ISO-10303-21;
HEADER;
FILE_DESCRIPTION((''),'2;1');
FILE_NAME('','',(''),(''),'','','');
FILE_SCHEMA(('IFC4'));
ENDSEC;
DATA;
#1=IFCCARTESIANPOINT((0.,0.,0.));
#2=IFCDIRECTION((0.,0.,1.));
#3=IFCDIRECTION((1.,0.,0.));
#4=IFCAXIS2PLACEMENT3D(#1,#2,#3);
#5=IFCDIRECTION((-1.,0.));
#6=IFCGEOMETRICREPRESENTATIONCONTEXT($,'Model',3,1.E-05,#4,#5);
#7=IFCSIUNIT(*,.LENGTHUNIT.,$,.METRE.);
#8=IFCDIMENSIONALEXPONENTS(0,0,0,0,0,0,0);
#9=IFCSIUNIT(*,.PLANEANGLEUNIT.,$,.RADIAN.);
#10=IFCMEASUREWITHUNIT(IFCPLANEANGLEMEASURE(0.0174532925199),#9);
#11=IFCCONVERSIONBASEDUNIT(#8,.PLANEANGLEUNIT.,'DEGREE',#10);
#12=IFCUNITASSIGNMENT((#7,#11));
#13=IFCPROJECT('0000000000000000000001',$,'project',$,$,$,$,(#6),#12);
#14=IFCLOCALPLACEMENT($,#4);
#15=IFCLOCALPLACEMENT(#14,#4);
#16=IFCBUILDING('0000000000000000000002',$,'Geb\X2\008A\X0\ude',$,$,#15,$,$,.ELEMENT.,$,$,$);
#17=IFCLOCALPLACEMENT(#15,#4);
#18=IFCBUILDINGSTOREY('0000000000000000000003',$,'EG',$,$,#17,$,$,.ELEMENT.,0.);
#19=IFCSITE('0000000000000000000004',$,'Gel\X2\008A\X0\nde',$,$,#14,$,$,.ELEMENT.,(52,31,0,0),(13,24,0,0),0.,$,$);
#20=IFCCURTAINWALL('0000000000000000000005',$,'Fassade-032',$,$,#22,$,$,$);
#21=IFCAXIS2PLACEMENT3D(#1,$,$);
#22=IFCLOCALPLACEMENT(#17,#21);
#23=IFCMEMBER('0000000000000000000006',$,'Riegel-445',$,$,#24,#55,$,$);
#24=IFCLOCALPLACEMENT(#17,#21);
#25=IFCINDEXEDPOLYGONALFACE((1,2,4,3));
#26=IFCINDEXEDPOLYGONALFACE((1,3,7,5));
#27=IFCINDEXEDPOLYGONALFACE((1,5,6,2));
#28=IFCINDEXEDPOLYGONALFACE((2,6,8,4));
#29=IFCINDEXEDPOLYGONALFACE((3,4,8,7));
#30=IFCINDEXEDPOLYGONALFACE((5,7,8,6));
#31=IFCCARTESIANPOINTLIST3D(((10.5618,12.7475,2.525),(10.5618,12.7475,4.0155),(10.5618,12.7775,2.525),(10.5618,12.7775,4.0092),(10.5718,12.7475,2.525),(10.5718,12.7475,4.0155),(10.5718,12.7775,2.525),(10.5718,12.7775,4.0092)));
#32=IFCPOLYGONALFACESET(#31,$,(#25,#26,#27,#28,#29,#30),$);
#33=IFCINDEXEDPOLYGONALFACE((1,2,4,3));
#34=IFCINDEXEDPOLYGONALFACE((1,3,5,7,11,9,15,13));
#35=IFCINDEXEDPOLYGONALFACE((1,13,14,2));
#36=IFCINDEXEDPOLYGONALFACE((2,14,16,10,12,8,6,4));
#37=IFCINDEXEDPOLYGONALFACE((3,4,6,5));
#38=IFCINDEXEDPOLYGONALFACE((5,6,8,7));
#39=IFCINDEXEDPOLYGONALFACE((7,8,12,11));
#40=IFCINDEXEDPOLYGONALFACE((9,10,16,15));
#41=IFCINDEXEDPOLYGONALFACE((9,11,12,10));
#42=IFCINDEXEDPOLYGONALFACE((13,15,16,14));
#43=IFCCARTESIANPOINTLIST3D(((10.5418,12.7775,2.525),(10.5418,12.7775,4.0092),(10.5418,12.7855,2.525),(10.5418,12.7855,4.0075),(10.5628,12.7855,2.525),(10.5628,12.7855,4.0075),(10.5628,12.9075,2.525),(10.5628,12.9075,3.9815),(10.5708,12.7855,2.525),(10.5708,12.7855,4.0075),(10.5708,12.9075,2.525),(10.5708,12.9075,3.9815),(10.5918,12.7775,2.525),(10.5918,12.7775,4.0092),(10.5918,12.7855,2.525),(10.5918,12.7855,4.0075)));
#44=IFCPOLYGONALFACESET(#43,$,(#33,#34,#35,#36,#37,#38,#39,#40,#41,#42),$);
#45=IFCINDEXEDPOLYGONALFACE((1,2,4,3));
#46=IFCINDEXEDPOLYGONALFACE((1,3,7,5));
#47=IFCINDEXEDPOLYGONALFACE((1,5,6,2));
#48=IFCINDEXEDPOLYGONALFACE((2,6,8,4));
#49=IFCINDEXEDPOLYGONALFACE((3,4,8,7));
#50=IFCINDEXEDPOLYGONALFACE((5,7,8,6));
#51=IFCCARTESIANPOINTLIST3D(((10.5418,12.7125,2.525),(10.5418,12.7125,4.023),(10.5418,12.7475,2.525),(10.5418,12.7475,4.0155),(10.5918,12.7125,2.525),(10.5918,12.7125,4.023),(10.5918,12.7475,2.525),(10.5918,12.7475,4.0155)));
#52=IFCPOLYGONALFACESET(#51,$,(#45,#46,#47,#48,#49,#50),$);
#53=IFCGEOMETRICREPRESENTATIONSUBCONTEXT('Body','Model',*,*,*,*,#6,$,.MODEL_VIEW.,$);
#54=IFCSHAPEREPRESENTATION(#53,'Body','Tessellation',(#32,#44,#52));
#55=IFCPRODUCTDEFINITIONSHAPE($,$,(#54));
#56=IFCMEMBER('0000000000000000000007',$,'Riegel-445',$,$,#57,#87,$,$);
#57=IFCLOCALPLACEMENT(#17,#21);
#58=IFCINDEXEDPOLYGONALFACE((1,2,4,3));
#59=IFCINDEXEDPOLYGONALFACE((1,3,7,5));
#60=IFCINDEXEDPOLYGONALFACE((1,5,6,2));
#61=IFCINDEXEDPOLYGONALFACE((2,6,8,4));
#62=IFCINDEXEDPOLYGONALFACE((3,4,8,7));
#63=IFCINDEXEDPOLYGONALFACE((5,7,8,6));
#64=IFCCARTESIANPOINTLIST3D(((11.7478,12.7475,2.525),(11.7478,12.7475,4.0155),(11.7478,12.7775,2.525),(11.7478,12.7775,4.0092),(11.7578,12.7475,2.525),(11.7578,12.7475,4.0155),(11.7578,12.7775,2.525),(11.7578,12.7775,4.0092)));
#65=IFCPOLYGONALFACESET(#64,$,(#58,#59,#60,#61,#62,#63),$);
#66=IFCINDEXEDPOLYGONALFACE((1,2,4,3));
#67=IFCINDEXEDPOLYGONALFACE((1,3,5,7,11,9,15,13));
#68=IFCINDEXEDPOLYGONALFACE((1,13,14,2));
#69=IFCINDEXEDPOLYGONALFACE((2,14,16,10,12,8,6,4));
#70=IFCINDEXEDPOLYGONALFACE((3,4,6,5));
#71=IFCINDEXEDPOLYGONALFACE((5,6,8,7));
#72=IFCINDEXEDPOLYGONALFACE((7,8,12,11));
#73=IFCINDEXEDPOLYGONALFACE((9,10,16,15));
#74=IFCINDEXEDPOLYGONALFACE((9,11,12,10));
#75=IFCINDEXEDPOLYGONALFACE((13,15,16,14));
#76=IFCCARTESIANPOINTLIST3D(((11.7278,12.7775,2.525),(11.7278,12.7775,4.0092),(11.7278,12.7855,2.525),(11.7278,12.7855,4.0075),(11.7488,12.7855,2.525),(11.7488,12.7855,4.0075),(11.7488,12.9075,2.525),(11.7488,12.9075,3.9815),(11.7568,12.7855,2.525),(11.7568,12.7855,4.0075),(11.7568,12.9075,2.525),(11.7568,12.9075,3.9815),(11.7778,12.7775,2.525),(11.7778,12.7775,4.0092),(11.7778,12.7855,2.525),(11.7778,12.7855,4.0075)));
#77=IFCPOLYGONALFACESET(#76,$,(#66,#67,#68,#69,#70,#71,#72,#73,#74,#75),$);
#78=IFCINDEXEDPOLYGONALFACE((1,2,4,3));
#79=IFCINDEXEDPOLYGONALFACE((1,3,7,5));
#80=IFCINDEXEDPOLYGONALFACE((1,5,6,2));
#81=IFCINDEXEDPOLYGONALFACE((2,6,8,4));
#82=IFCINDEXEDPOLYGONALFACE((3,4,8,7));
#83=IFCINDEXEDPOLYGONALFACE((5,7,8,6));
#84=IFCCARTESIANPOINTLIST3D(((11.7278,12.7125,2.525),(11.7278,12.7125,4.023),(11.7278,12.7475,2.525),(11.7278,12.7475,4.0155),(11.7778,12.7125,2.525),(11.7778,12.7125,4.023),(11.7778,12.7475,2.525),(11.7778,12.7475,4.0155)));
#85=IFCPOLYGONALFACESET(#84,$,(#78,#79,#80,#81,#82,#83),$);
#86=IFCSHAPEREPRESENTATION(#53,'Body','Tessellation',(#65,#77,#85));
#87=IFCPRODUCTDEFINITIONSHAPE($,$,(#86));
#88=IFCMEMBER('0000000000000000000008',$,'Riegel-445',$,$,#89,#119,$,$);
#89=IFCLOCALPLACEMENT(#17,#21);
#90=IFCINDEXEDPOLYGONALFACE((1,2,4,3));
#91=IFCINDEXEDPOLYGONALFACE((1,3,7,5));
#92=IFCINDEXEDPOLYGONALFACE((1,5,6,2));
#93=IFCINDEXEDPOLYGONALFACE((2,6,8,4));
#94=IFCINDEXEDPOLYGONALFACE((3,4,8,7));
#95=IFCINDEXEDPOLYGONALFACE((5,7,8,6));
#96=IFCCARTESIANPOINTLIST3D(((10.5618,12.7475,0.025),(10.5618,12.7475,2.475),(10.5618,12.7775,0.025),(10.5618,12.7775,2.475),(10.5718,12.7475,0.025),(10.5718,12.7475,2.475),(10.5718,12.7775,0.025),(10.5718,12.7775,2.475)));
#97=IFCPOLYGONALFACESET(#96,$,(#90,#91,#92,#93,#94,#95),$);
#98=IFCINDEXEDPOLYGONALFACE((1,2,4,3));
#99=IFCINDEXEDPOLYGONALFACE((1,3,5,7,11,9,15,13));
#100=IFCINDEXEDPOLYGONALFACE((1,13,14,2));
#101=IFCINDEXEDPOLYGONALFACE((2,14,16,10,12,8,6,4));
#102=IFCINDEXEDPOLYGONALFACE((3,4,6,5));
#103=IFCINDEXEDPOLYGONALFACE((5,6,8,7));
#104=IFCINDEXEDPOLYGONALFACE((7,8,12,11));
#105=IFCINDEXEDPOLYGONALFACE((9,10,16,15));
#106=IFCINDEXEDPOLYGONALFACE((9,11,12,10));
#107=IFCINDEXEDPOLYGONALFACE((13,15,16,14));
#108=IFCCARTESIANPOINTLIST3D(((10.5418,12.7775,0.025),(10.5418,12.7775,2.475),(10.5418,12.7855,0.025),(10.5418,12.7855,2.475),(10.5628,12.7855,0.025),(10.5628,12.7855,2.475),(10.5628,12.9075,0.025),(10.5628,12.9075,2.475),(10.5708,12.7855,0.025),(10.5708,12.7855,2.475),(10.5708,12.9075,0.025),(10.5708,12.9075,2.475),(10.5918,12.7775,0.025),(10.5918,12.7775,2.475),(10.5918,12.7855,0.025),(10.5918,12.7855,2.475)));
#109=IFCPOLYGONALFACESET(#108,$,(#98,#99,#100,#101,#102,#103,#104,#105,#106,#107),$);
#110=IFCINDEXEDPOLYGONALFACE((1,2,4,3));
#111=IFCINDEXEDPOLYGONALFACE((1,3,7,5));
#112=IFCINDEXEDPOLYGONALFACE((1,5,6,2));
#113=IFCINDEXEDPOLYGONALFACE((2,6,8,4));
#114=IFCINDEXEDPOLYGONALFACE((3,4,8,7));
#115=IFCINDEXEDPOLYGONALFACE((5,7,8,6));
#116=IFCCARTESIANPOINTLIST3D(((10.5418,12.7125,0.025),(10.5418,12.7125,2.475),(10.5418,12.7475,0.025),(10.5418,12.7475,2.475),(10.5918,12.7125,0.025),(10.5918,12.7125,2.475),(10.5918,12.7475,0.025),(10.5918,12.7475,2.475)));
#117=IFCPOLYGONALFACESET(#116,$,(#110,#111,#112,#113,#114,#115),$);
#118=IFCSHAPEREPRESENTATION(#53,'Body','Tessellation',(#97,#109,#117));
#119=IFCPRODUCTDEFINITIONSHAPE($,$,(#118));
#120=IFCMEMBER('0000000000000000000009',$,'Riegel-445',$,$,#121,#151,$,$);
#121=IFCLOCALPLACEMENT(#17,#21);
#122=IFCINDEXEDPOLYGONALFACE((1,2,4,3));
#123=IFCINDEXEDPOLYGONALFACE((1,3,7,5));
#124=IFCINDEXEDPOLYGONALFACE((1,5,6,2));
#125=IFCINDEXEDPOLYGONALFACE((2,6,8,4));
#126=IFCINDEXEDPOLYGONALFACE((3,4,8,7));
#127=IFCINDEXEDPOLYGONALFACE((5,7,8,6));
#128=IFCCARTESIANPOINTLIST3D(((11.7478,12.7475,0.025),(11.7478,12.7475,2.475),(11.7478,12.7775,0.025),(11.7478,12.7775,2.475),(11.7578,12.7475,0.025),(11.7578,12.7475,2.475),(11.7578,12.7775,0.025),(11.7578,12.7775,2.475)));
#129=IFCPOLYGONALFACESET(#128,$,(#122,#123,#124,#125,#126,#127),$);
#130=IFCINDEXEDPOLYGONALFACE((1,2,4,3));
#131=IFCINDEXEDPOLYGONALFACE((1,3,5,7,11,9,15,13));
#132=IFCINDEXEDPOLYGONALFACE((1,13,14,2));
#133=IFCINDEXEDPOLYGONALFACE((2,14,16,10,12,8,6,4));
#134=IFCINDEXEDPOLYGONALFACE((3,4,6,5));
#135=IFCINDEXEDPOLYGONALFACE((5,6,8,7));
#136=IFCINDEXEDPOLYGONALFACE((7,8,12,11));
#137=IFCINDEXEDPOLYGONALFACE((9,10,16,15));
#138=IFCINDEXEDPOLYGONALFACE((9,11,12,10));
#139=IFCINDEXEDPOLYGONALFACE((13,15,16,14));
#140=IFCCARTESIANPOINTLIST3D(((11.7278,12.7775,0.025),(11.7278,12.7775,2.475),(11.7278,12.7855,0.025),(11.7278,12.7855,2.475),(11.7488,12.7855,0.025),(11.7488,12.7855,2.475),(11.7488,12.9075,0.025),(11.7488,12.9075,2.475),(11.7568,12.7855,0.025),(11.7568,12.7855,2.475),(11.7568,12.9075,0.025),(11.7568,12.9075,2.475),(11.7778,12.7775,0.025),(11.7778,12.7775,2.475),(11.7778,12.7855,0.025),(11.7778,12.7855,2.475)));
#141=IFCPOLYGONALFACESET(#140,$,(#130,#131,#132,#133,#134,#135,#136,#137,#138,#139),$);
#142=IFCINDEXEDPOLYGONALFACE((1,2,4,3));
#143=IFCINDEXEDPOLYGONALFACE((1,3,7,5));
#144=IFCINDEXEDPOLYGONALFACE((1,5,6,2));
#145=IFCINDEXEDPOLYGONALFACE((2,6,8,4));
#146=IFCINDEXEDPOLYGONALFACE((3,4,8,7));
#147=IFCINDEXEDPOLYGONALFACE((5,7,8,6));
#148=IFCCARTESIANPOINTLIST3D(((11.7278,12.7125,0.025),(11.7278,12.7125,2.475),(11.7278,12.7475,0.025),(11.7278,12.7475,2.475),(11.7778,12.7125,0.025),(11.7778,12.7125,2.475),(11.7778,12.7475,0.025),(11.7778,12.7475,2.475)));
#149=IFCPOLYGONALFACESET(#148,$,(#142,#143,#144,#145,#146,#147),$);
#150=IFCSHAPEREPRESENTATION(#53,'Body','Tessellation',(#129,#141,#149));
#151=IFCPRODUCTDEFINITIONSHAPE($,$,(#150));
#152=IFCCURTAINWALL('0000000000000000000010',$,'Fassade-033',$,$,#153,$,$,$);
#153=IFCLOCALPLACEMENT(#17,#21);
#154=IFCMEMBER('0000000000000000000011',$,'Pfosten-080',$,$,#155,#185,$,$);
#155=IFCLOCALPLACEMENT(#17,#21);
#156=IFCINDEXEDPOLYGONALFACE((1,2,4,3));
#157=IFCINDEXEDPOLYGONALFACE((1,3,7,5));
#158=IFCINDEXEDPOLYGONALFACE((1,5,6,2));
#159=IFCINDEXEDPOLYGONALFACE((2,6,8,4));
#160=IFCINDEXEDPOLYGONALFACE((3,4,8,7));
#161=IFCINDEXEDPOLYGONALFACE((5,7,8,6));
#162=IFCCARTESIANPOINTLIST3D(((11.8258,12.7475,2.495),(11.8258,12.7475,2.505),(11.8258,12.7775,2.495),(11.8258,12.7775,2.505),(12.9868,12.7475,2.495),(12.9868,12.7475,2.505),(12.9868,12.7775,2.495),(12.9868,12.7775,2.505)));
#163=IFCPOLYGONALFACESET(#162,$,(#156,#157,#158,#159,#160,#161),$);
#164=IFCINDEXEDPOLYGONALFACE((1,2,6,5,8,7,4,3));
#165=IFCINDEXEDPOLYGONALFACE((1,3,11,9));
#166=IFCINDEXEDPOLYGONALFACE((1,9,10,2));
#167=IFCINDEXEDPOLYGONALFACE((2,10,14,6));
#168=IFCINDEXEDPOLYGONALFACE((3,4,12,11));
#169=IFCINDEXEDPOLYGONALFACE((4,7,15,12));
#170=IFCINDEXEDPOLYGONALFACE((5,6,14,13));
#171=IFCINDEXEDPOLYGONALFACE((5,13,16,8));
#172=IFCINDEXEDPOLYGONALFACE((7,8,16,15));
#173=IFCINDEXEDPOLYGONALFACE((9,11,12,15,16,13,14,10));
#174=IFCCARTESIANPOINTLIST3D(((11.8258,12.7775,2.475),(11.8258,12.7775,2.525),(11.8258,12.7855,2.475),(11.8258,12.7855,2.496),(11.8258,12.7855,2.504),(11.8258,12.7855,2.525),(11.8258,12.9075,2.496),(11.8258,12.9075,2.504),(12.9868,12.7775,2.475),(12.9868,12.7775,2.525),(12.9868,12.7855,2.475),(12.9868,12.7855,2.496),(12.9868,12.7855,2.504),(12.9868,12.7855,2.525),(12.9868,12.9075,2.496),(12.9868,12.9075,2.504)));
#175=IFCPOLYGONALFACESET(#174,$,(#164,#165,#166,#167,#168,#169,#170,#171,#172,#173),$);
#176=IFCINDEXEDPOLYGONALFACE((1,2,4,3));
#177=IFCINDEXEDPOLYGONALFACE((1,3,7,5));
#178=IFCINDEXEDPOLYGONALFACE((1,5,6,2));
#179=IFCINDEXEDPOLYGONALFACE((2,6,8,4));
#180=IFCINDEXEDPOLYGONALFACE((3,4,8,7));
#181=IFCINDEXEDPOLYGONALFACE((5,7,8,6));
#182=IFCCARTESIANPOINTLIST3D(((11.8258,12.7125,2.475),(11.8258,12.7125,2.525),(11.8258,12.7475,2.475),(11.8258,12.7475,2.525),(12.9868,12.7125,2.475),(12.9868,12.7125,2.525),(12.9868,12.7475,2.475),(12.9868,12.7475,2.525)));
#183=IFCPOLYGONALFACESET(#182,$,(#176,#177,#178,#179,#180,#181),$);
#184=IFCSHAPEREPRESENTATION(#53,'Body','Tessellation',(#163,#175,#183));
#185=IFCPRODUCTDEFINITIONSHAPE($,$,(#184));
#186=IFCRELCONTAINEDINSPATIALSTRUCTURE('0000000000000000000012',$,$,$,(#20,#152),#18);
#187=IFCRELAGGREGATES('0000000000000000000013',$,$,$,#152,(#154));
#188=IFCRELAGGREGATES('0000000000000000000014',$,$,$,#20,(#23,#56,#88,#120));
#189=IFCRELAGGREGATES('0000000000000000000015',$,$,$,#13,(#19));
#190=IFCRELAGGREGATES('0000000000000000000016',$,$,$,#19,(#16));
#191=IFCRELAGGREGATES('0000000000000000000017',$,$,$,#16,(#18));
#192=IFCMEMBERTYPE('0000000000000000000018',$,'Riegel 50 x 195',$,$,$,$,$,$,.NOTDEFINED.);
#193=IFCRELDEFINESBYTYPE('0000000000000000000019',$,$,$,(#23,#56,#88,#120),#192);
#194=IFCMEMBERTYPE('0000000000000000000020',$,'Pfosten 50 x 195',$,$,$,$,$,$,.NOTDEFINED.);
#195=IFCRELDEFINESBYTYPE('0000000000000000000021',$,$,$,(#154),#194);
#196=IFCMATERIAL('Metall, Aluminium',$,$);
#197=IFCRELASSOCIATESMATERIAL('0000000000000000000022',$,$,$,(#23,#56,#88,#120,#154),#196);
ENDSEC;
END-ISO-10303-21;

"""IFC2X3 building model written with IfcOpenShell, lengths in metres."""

from ifc_helpers import new_model, entity, si_unit, converted_unit, direction, frame, origin_with_axes, place, context, subcontext, project, spatial, polyline, outline, extrude, clip, halfspace, material, type_object, element, aggregate, save


model = new_model("IFC2X3")

# Units and contexts
model_context = context("Model", 3, precision=1e-05, world=origin_with_axes(), true_north=direction((-1.0, 0.0)))
body_context = subcontext(model_context, "Body", "Model", "MODEL_VIEW")
ifc_project = project(units=[si_unit("LENGTHUNIT", "METRE"), converted_unit("PLANEANGLEUNIT", "DEGREE", entity("IfcPlaneAngleMeasure", 0.0174532925199), si_unit("PLANEANGLEUNIT", "RADIAN"), dimensions=[0, 0, 0, 0, 0, 0, 0])], contexts=[model_context])

# Site, building, storey
site_placement = place(None, origin_with_axes())
site = spatial("IfcSite", under=ifc_project, at=site_placement, Name="Gel\u008ande", CompositionType="ELEMENT", RefLatitude=(52, 31, 0, 0), RefLongitude=(13, 24, 0, 0), RefElevation=0.0)
building_placement = place(site_placement, origin_with_axes())
building = spatial("IfcBuilding", under=site, at=building_placement, Name="Geb\u008aude", CompositionType="ELEMENT")
storey_placement = place(building_placement, origin_with_axes())
storey = spatial("IfcBuildingStorey", under=building, at=storey_placement, Name="EG", CompositionType="ELEMENT", Elevation=0.0)

# Curtain wall, members
curtain_wall_1_placement = place(storey_placement, frame((9.9738, 12.7625, 0.0), z_axis=(0.0, 0.0, 1.0), x_axis=(1.0, 0.0, 0.0)))
curtain_wall_1 = element("IfcCurtainWall", 1, at=curtain_wall_1_placement, inside=storey, Name="Fassade-032")
ifc_material = material(Name="Metall, Aluminium")
member_type_1 = type_object("IfcMemberType", Name="Riegel 50 x 195", PredefinedType="NOTDEFINED")
member_1_placement = place(curtain_wall_1_placement, frame((0.593, 0.0, 2.5), z_axis=(0.0, 0.0, 1.0), x_axis=(-1.0, 0.0, 0.0)))
member_1 = element("IfcMember", 2, at=member_1_placement, type_object=member_type_1, material=ifc_material, Name="Riegel-445", context=body_context, shape_type="Clipping", body=[
    clip(extrude(outline(polyline([(0.005, 0.015), (-0.005, 0.015), (-0.005, -0.015), (0.005, -0.015), (0.005, 0.015)])), frame((0.0, 0.0, 0.025), z_axis=(0.0, 0.0, 1.0), x_axis=(-1.0, 0.0, 0.0)), (0.0, 0.0, 1.0), 1.4905), halfspace(frame((0.0, -0.3076, 1.447), z_axis=(0.0, 0.207912, -0.978148), x_axis=(0.0, -0.978148, -0.207912)), True)),
    clip(extrude(outline(polyline([(0.025, 0.023), (0.004, 0.023), (0.004, 0.145), (-0.004, 0.145), (-0.004, 0.023), (-0.025, 0.023), (-0.025, 0.015), (0.025, 0.015), (0.025, 0.023)])), frame((0.0, 0.0, 0.025), z_axis=(0.0, 0.0, 1.0), x_axis=(-1.0, 0.0, 0.0)), (0.0, 0.0, 1.0), 1.4842), halfspace(frame((0.0, -0.3076, 1.447), z_axis=(0.0, 0.207912, -0.978148), x_axis=(0.0, -0.978148, -0.207912)), True)),
    clip(extrude(outline(polyline([(0.025, -0.015), (-0.025, -0.015), (-0.025, -0.05), (0.025, -0.05), (0.025, -0.015)])), frame((0.0, 0.0, 0.025), z_axis=(0.0, 0.0, 1.0), x_axis=(-1.0, 0.0, 0.0)), (0.0, 0.0, 1.0), 1.498), halfspace(frame((0.0, -0.3076, 1.447), z_axis=(0.0, 0.207912, -0.978148), x_axis=(0.0, -0.978148, -0.207912)), True)),
])
member_2_placement = place(curtain_wall_1_placement, frame((1.779, 0.0, 2.5), z_axis=(0.0, 0.0, 1.0), x_axis=(-1.0, 0.0, 0.0)))
member_2 = element("IfcMember", 3, at=member_2_placement, type_object=member_type_1, material=ifc_material, Name="Riegel-445", context=body_context, shape_type="Clipping", body=[
    clip(extrude(outline(polyline([(0.005, 0.015), (-0.005, 0.015), (-0.005, -0.015), (0.005, -0.015), (0.005, 0.015)])), frame((0.0, 0.0, 0.025), z_axis=(0.0, 0.0, 1.0), x_axis=(-1.0, 0.0, 0.0)), (0.0, 0.0, 1.0), 1.4905), halfspace(frame((0.0, -0.3076, 1.447), z_axis=(0.0, 0.207912, -0.978148), x_axis=(0.0, -0.978148, -0.207912)), True)),
    clip(extrude(outline(polyline([(0.025, 0.023), (0.004, 0.023), (0.004, 0.145), (-0.004, 0.145), (-0.004, 0.023), (-0.025, 0.023), (-0.025, 0.015), (0.025, 0.015), (0.025, 0.023)])), frame((0.0, 0.0, 0.025), z_axis=(0.0, 0.0, 1.0), x_axis=(-1.0, 0.0, 0.0)), (0.0, 0.0, 1.0), 1.4842), halfspace(frame((0.0, -0.3076, 1.447), z_axis=(0.0, 0.207912, -0.978148), x_axis=(0.0, -0.978148, -0.207912)), True)),
    clip(extrude(outline(polyline([(0.025, -0.015), (-0.025, -0.015), (-0.025, -0.05), (0.025, -0.05), (0.025, -0.015)])), frame((0.0, 0.0, 0.025), z_axis=(0.0, 0.0, 1.0), x_axis=(-1.0, 0.0, 0.0)), (0.0, 0.0, 1.0), 1.498), halfspace(frame((0.0, -0.3076, 1.447), z_axis=(0.0, 0.207912, -0.978148), x_axis=(0.0, -0.978148, -0.207912)), True)),
])
member_3_placement = place(curtain_wall_1_placement, frame((0.593, 0.0, 0.0), z_axis=(0.0, 0.0, 1.0), x_axis=(-1.0, 0.0, 0.0)))
member_3 = element("IfcMember", 4, at=member_3_placement, type_object=member_type_1, material=ifc_material, Name="Riegel-445", context=body_context, shape_type="SweptSolid", body=[
    extrude(outline(polyline([(-0.005, 0.015), (-0.005, -0.015), (0.005, -0.015), (0.005, 0.015), (-0.005, 0.015)])), frame((0.0, 0.0, 0.025), z_axis=(0.0, 0.0, 1.0), x_axis=(-1.0, 0.0, 0.0)), (0.0, 0.0, 1.0), 2.45),
    extrude(outline(polyline([(-0.004, 0.145), (-0.004, 0.023), (-0.025, 0.023), (-0.025, 0.015), (0.025, 0.015), (0.025, 0.023), (0.004, 0.023), (0.004, 0.145), (-0.004, 0.145)])), frame((0.0, 0.0, 0.025), z_axis=(0.0, 0.0, 1.0), x_axis=(-1.0, 0.0, 0.0)), (0.0, 0.0, 1.0), 2.45),
    extrude(outline(polyline([(0.025, -0.05), (0.025, -0.015), (-0.025, -0.015), (-0.025, -0.05), (0.025, -0.05)])), frame((0.0, 0.0, 0.025), z_axis=(0.0, 0.0, 1.0), x_axis=(-1.0, 0.0, 0.0)), (0.0, 0.0, 1.0), 2.45),
])
member_4_placement = place(curtain_wall_1_placement, frame((1.779, 0.0, 0.0), z_axis=(0.0, 0.0, 1.0), x_axis=(-1.0, 0.0, 0.0)))
member_4 = element("IfcMember", 5, at=member_4_placement, type_object=member_type_1, material=ifc_material, Name="Riegel-445", context=body_context, shape_type="SweptSolid", body=[
    extrude(outline(polyline([(-0.005, 0.015), (-0.005, -0.015), (0.005, -0.015), (0.005, 0.015), (-0.005, 0.015)])), frame((0.0, 0.0, 0.025), z_axis=(0.0, 0.0, 1.0), x_axis=(-1.0, 0.0, 0.0)), (0.0, 0.0, 1.0), 2.45),
    extrude(outline(polyline([(-0.004, 0.145), (-0.004, 0.023), (-0.025, 0.023), (-0.025, 0.015), (0.025, 0.015), (0.025, 0.023), (0.004, 0.023), (0.004, 0.145), (-0.004, 0.145)])), frame((0.0, 0.0, 0.025), z_axis=(0.0, 0.0, 1.0), x_axis=(-1.0, 0.0, 0.0)), (0.0, 0.0, 1.0), 2.45),
    extrude(outline(polyline([(0.025, -0.05), (0.025, -0.015), (-0.025, -0.015), (-0.025, -0.05), (0.025, -0.05)])), frame((0.0, 0.0, 0.025), z_axis=(0.0, 0.0, 1.0), x_axis=(-1.0, 0.0, 0.0)), (0.0, 0.0, 1.0), 2.45),
])

# Curtain wall, member
curtain_wall_2_placement = place(storey_placement, frame((12.3938, 12.7625, 0.0), z_axis=(0.0, 0.0, 1.0), x_axis=(1.0, 0.0, 0.0)))
curtain_wall_2 = element("IfcCurtainWall", 6, at=curtain_wall_2_placement, inside=storey, Name="Fassade-033")
member_type_2 = type_object("IfcMemberType", Name="Pfosten 50 x 195", PredefinedType="NOTDEFINED")
member_5_placement = place(curtain_wall_2_placement, frame((-0.593, 0.0, 2.5), z_axis=(1.0, 0.0, 0.0), x_axis=(0.0, 0.0, 1.0)))
member_5 = element("IfcMember", 7, at=member_5_placement, type_object=member_type_2, material=ifc_material, Name="Pfosten-080", context=body_context, shape_type="SweptSolid", body=[
    extrude(outline(polyline([(-0.015, -0.005), (0.015, -0.005), (0.015, 0.005), (-0.015, 0.005), (-0.015, -0.005)])), frame((0.0, 0.0, 0.025), z_axis=(0.0, 0.0, 1.0), x_axis=(0.0, 1.0, 0.0)), (0.0, 0.0, 1.0), 1.161),
    extrude(outline(polyline([(-0.145, -0.004), (-0.023, -0.004), (-0.023, -0.025), (-0.015, -0.025), (-0.015, 0.025), (-0.023, 0.025), (-0.023, 0.004), (-0.145, 0.004), (-0.145, -0.004)])), frame((0.0, 0.0, 0.025), z_axis=(0.0, 0.0, 1.0), x_axis=(0.0, 1.0, 0.0)), (0.0, 0.0, 1.0), 1.161),
    extrude(outline(polyline([(0.05, 0.025), (0.015, 0.025), (0.015, -0.025), (0.05, -0.025), (0.05, 0.025)])), frame((0.0, 0.0, 0.025), z_axis=(0.0, 0.0, 1.0), x_axis=(0.0, 1.0, 0.0)), (0.0, 0.0, 1.0), 1.161),
])

aggregate(curtain_wall_2, [member_5])
aggregate(curtain_wall_1, [member_1, member_2, member_3, member_4])

save(model, "model.ifc")
